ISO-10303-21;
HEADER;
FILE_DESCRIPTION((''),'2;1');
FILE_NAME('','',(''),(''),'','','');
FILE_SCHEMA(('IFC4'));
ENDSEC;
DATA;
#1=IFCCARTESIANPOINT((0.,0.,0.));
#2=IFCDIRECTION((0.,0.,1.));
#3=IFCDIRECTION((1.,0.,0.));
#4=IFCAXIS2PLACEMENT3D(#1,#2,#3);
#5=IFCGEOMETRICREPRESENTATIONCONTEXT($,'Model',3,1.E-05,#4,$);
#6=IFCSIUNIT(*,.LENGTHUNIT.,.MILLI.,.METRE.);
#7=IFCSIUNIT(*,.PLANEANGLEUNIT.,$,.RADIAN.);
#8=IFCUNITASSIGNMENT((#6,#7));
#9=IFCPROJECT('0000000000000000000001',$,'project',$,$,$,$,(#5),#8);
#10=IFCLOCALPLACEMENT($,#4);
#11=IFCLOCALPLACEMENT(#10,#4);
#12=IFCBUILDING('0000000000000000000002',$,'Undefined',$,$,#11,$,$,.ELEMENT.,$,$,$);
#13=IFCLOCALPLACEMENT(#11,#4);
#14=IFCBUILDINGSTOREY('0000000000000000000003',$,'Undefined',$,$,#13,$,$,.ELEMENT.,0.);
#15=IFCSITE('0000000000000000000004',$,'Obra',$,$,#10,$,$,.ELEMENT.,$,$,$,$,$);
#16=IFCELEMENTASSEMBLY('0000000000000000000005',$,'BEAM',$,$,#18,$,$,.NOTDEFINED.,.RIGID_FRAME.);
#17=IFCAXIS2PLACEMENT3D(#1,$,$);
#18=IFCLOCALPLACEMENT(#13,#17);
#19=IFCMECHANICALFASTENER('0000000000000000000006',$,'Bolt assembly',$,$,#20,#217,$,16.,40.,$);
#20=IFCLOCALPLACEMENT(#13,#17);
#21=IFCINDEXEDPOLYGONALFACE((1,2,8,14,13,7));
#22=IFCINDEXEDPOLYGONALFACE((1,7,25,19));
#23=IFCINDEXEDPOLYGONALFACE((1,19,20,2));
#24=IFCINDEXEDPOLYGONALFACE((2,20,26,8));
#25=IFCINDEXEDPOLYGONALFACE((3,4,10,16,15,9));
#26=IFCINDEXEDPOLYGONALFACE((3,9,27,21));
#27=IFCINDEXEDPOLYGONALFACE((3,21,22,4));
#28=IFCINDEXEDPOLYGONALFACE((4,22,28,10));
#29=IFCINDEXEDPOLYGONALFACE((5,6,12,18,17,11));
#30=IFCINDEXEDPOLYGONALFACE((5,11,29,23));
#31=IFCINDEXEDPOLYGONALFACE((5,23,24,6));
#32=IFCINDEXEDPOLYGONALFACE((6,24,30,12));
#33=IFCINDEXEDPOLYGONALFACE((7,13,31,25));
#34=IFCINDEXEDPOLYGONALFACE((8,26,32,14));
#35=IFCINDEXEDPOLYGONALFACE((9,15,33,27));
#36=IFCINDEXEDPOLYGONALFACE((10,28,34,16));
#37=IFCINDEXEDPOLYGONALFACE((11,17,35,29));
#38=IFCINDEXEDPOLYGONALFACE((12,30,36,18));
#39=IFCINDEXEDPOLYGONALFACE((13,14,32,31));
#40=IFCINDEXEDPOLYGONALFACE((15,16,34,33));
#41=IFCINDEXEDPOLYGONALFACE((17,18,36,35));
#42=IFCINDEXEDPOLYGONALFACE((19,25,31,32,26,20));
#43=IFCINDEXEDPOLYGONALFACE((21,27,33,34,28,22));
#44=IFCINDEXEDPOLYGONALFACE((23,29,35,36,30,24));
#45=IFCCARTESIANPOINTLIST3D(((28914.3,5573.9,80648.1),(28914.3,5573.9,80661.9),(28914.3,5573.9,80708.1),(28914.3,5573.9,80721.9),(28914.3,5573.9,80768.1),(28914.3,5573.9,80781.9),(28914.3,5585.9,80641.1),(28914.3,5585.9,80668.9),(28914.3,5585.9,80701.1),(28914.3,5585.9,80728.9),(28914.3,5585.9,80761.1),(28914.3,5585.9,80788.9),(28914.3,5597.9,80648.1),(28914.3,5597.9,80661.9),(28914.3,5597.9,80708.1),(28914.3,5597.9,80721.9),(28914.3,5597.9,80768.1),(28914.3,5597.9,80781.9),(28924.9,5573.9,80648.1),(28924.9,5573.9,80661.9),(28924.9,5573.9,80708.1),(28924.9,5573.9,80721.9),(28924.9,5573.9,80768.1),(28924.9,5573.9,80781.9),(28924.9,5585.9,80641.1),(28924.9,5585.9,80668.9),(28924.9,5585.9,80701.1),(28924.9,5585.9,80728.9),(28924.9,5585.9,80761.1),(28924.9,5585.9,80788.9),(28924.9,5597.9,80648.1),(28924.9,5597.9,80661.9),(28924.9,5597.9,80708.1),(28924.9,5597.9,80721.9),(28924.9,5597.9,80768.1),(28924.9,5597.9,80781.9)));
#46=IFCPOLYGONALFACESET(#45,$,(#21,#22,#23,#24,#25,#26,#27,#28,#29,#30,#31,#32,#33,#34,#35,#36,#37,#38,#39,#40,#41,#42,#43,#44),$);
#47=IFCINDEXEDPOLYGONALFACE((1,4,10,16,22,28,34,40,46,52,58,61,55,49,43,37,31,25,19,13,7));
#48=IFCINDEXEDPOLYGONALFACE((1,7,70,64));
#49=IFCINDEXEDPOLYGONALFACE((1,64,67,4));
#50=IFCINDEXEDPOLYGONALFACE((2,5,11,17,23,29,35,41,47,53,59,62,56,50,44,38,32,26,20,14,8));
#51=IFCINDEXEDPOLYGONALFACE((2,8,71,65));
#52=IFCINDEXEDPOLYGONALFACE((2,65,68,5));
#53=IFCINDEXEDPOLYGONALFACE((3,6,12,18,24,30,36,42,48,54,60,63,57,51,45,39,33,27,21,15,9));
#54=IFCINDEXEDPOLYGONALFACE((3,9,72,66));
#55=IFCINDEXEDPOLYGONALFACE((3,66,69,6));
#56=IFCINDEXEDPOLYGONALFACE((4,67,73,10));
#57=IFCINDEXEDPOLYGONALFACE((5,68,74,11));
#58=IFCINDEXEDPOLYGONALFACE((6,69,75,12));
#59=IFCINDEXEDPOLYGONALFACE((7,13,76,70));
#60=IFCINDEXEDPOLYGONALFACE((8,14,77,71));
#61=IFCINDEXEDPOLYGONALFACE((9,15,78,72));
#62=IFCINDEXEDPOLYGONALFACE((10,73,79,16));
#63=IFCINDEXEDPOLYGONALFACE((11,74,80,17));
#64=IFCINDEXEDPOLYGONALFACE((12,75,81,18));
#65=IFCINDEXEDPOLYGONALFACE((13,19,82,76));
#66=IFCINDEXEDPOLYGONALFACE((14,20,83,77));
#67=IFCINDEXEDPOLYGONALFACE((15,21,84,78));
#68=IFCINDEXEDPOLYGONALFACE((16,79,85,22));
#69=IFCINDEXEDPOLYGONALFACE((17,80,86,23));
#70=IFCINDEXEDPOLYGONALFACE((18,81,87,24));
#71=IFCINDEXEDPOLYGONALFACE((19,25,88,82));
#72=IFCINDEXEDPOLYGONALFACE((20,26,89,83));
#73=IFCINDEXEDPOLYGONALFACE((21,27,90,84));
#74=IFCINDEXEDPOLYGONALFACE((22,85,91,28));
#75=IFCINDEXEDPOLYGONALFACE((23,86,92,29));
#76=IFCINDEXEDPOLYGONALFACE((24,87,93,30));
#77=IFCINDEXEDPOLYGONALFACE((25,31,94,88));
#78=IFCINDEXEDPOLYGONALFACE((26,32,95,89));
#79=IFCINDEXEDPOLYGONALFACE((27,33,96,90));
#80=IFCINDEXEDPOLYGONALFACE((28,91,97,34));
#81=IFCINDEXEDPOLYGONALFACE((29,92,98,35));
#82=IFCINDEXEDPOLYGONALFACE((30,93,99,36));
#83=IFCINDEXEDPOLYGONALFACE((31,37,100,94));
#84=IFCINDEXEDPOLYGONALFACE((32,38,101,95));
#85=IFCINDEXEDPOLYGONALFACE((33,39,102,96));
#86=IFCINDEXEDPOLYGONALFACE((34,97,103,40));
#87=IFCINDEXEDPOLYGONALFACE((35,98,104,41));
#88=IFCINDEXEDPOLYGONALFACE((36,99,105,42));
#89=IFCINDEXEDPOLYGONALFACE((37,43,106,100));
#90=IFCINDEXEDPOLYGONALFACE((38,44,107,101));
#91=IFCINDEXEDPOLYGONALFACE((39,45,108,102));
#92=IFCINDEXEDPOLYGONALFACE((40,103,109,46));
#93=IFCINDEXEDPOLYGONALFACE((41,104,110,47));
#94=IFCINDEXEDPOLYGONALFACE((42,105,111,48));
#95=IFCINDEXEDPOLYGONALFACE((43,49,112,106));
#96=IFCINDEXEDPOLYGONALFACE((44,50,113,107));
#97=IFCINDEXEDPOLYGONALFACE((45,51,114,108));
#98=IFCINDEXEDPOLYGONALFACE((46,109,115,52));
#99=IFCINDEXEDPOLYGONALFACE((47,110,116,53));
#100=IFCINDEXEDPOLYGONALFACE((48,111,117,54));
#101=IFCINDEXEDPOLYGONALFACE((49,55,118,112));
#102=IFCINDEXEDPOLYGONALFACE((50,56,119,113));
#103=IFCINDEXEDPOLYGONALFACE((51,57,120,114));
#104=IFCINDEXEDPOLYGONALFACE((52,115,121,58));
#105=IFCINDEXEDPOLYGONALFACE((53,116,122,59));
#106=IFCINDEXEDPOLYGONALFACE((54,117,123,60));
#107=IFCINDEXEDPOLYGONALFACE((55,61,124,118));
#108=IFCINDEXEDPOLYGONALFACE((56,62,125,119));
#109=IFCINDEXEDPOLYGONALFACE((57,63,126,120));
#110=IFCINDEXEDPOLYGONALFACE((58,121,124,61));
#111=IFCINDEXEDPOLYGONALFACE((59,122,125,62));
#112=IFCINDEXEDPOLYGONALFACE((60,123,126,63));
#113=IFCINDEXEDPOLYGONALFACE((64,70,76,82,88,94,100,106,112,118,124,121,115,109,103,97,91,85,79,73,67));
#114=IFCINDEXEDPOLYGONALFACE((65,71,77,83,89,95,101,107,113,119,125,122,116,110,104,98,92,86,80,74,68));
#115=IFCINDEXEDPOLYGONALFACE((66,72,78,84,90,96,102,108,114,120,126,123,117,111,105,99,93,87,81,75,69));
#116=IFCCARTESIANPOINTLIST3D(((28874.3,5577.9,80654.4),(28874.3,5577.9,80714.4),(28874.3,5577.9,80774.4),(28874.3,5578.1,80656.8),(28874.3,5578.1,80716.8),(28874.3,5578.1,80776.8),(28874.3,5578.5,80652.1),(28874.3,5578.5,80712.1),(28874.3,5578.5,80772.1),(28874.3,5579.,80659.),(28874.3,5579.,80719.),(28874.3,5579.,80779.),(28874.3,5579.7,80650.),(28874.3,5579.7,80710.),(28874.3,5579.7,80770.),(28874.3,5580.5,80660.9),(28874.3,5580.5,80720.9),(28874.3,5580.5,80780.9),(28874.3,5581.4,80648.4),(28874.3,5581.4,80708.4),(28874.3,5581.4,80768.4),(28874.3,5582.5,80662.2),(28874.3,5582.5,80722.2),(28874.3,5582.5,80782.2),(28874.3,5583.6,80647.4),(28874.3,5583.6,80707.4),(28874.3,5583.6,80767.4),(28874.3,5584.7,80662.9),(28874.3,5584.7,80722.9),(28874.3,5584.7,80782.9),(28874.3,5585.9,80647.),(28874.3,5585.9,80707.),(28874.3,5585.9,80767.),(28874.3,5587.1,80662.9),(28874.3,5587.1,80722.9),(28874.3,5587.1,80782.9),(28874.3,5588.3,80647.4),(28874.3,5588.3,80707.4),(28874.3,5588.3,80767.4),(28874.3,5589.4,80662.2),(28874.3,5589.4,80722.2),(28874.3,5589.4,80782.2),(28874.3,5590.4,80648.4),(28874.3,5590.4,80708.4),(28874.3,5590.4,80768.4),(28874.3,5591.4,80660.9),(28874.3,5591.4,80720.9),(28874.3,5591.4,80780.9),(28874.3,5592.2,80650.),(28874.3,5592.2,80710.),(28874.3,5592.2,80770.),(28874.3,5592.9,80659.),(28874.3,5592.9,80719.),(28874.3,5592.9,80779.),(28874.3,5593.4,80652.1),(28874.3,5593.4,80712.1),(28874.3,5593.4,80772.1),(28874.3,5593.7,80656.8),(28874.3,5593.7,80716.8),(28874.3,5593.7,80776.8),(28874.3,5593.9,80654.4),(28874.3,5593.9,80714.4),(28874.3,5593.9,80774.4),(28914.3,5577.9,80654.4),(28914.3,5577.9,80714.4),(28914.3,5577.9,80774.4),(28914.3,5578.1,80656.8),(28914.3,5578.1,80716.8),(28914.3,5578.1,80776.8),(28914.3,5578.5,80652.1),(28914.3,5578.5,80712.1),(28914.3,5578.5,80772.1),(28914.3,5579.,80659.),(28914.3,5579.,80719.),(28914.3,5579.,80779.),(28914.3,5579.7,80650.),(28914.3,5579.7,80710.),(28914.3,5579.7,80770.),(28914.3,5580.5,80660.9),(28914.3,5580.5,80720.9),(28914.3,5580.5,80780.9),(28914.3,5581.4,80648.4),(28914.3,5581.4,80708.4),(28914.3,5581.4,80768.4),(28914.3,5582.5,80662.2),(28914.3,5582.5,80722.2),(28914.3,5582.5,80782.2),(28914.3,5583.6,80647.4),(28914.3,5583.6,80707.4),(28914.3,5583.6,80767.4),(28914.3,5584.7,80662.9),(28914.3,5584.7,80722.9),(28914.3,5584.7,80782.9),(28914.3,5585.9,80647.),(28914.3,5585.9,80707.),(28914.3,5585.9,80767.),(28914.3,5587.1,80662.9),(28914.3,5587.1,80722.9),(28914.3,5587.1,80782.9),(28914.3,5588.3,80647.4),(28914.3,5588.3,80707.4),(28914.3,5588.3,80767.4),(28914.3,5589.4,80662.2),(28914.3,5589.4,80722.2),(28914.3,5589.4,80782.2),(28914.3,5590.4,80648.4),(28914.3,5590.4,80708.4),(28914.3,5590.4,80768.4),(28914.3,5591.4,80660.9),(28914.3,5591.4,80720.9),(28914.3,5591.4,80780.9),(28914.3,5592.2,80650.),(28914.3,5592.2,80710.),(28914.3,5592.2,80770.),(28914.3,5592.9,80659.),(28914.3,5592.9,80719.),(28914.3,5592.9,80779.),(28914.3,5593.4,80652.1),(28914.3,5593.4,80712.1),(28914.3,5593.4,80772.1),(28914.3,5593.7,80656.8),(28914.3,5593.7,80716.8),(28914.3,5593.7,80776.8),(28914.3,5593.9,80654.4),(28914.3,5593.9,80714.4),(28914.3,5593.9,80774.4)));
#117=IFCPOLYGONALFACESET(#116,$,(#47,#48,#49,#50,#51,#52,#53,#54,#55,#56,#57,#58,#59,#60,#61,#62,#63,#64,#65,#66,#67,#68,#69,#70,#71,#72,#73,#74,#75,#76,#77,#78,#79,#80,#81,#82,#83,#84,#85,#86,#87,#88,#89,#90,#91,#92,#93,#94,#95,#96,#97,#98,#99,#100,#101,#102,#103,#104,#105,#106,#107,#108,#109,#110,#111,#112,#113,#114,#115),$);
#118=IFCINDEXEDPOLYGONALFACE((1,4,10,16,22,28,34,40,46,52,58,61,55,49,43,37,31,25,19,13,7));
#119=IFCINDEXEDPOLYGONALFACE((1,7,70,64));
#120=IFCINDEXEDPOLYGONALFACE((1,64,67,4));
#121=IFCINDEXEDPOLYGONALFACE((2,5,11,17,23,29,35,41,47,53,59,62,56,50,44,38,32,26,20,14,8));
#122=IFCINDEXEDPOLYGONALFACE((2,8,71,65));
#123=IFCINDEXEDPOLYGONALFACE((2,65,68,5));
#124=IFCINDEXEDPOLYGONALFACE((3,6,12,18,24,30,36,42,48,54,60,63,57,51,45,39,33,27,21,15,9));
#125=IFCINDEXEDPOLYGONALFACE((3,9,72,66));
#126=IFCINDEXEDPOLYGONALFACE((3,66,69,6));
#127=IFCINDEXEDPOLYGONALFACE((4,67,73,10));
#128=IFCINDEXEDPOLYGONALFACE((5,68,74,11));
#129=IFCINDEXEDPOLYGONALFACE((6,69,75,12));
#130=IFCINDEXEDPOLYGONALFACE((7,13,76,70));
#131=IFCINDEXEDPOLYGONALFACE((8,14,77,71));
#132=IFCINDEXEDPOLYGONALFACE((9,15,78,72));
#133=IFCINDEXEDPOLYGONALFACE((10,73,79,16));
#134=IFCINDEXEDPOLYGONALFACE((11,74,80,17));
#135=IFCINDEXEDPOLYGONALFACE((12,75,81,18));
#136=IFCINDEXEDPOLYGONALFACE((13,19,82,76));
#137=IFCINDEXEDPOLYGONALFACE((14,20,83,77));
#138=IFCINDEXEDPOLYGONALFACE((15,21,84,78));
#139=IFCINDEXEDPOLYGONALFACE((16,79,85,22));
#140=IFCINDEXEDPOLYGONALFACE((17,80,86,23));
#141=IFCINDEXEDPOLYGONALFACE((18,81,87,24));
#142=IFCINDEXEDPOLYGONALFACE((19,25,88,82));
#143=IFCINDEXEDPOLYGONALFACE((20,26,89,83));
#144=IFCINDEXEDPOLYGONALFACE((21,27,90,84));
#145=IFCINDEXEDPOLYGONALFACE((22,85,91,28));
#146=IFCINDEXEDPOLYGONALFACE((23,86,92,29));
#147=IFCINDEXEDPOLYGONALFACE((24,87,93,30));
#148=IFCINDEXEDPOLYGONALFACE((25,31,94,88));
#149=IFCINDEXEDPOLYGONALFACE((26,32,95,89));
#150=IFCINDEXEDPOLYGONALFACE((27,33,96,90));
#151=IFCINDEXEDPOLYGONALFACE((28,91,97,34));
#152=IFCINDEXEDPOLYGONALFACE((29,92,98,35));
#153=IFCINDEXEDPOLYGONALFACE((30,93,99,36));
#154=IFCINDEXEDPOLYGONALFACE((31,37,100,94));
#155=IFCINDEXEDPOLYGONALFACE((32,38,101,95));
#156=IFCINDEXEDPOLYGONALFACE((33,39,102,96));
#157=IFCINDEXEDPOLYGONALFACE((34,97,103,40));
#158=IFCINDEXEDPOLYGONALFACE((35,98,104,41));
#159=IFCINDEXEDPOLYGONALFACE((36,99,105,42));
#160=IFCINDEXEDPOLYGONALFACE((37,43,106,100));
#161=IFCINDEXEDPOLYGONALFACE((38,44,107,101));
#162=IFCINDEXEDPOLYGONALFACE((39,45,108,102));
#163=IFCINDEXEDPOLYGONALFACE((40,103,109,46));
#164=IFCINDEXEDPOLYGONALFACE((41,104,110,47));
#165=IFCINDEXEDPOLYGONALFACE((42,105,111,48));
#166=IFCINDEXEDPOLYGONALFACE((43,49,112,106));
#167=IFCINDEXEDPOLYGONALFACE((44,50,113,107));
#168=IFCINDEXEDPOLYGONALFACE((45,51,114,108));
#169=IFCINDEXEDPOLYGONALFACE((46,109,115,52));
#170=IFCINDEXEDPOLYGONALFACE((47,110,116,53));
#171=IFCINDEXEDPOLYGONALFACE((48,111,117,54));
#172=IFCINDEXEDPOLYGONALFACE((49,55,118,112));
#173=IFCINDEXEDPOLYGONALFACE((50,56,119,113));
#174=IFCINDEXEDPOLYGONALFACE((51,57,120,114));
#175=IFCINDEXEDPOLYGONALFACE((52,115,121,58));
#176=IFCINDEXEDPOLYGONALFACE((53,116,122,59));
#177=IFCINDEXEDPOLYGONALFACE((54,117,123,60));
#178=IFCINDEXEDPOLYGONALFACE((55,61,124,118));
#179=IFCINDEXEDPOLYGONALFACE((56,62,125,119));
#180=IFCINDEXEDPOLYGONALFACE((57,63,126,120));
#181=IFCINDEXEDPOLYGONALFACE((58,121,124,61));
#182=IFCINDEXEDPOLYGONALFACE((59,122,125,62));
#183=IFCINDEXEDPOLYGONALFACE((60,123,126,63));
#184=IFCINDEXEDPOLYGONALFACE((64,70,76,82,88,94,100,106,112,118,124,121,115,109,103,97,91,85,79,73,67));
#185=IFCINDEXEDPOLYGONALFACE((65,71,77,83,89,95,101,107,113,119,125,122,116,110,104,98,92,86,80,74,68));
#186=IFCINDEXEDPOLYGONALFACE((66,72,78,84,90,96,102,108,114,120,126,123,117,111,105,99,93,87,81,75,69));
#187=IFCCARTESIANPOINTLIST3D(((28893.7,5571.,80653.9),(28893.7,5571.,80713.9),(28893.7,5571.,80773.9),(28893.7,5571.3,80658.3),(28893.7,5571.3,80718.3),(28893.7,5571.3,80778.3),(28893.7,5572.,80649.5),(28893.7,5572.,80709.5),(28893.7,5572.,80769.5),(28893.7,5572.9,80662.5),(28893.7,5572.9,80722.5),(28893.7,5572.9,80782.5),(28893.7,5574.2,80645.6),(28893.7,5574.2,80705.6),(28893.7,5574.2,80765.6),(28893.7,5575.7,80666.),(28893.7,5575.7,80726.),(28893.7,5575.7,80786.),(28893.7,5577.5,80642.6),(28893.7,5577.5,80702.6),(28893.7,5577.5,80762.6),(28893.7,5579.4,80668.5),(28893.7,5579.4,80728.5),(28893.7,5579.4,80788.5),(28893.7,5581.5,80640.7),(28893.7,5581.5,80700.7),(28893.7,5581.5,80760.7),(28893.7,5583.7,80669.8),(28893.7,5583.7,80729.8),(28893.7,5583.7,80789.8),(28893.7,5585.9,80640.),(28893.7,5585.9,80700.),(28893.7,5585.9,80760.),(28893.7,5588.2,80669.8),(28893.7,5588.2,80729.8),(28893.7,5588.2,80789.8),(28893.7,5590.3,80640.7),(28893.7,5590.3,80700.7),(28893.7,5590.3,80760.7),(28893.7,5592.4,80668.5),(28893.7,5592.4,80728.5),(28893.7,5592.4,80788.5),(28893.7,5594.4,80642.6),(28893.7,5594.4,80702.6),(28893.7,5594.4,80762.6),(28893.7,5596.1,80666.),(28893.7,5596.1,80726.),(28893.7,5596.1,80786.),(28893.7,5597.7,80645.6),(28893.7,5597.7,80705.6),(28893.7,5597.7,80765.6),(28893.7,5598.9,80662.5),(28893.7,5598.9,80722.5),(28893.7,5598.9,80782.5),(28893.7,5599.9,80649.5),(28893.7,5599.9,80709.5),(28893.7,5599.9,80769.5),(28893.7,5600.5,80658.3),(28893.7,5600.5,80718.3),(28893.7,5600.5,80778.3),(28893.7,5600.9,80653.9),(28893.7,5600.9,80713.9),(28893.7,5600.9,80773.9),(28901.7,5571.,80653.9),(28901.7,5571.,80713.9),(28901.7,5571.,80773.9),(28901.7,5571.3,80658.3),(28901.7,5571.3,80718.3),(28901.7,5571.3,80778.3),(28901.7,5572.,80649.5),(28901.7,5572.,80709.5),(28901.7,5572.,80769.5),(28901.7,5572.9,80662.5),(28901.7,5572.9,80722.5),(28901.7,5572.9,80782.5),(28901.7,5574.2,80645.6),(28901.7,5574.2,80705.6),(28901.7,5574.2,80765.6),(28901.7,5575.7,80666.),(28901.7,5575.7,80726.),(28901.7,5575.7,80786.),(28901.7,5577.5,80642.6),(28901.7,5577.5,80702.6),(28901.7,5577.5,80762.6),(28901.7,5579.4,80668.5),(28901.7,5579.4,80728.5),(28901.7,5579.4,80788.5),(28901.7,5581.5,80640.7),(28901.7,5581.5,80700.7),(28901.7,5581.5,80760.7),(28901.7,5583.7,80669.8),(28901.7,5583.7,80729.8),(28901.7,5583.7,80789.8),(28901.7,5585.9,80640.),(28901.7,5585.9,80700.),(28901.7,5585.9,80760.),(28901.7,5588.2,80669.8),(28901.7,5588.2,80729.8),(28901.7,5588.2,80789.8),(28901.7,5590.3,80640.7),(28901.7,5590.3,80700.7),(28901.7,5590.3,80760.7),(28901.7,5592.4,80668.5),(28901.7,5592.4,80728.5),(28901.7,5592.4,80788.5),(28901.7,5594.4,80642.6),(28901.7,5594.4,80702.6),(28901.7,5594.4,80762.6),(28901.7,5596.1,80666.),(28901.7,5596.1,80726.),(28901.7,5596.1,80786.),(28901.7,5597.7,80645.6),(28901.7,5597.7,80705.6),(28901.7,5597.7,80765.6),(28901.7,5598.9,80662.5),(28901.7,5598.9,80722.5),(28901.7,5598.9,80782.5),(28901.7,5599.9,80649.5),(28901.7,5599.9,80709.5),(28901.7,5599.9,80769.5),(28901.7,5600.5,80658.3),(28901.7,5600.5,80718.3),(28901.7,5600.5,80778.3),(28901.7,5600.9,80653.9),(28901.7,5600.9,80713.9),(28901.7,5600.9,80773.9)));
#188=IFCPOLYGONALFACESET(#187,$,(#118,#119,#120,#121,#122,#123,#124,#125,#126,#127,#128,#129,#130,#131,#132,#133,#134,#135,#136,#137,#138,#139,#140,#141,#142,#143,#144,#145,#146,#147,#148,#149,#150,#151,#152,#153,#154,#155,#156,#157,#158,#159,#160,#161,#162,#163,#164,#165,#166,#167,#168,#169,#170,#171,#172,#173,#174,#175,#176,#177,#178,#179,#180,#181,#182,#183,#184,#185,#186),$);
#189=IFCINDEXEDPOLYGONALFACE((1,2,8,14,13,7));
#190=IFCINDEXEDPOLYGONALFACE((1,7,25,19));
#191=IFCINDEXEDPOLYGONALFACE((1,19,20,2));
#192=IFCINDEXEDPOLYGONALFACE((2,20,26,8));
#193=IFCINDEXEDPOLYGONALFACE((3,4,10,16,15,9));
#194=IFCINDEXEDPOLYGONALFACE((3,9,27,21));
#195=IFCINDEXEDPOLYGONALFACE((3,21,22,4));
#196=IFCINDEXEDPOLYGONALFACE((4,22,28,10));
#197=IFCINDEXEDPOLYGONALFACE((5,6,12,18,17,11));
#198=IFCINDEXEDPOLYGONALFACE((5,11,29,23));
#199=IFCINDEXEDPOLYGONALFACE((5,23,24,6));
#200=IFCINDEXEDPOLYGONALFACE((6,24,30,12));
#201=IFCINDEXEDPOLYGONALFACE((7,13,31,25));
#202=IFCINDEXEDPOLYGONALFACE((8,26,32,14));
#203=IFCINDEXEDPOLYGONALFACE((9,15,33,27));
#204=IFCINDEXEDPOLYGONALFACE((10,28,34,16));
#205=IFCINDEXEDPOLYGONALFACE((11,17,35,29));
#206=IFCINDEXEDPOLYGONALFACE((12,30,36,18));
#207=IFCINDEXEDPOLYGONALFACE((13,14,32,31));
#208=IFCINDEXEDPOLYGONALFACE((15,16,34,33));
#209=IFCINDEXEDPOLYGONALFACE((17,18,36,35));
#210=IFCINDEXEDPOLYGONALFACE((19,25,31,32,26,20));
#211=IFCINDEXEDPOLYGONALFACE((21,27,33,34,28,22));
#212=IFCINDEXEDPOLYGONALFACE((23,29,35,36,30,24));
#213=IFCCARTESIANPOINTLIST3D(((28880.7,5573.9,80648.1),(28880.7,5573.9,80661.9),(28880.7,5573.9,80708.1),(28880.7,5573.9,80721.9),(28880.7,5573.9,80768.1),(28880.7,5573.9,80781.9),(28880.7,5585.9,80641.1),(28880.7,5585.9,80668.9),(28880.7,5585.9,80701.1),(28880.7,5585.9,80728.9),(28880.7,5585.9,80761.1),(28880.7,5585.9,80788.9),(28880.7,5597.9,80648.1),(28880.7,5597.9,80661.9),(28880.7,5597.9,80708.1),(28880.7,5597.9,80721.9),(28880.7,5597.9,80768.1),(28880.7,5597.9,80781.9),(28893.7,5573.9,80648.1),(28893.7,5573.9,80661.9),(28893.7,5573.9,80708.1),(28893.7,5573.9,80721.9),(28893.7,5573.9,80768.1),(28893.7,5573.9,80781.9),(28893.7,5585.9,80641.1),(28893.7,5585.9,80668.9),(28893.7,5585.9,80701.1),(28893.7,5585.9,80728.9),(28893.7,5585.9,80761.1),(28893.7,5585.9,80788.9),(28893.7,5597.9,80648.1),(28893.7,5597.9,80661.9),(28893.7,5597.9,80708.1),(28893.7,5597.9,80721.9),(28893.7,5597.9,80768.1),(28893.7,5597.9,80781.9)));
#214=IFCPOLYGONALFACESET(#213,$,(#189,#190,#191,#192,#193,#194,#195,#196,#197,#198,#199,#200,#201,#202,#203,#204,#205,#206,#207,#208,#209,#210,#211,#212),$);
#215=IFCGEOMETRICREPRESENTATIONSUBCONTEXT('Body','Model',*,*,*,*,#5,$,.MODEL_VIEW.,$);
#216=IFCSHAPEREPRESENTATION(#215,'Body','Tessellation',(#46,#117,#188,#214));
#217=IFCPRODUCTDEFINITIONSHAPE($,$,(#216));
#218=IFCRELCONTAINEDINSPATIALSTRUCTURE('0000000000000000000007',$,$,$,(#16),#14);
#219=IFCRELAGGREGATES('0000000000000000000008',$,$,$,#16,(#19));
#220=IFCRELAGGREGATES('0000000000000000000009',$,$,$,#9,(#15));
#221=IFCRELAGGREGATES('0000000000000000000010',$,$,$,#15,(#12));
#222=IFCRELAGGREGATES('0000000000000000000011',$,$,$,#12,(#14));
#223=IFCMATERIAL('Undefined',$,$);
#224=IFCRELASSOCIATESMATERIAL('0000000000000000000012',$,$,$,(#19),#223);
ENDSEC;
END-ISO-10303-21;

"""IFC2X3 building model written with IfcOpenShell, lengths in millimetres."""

from ifc_helpers import new_model, si_unit, frame, origin_with_axes, origin_2d_with_axis, place, context, subcontext, project, spatial, polyline, circle, outline, extrude, source, transform, mapped, material, element, aggregate, save


model = new_model("IFC2X3")

# Units and contexts
model_context = context("Model", 3, precision=1e-05, world=origin_with_axes())
body_context = subcontext(model_context, "Body", "Model", "MODEL_VIEW")
ifc_project = project(units=[si_unit("LENGTHUNIT", "METRE", prefix="MILLI"), si_unit("PLANEANGLEUNIT", "RADIAN")], contexts=[model_context])

# Site, building, storey
site_placement = place(None, origin_with_axes())
site = spatial("IfcSite", under=ifc_project, at=site_placement, Name="Obra", CompositionType="ELEMENT")
building_placement = place(site_placement, origin_with_axes())
building = spatial("IfcBuilding", under=site, at=building_placement, Name="Undefined", CompositionType="ELEMENT")
storey_placement = place(building_placement, origin_with_axes())
storey = spatial("IfcBuildingStorey", under=building, at=storey_placement, Name="Undefined", CompositionType="ELEMENT", Elevation=0.0)

# Shared definitions
ifc_material_1 = material(Name="Undefined")

# Element assembly, mechanical fastener
assembly_1_placement = place(storey_placement, origin_with_axes())
assembly_1 = element("IfcElementAssembly", 1, at=assembly_1_placement, inside=storey, Name="BEAM", AssemblyPlace="NOTDEFINED", PredefinedType="RIGID_FRAME")
shared_shape_1 = source(origin_with_axes(), body_context, "Body", "SweptSolid", [
    extrude(outline(polyline([(13.9, 0.0), (6.9, 12.0), (-6.9, 12.0), (-13.9, 0.0), (-6.9, -12.0), (6.9, -12.0), (13.9, 0.0)])), frame((0.0, -19.9, 0.0), z_axis=(0.0, 1.0, 0.0), x_axis=(1.0, 0.0, 0.0)), (0.0, 0.0, 1.0), 10.6),
    extrude(circle(Radius=8.0, at=origin_2d_with_axis()), frame((0.0, -9.3, 0.0), z_axis=(0.0, 1.0, 0.0), x_axis=(1.0, 0.0, 0.0)), (0.0, 0.0, 1.0), 40.0),
    extrude(circle(Radius=15.0, at=origin_2d_with_axis()), frame((0.0, 3.3, 0.0), z_axis=(0.0, 1.0, 0.0), x_axis=(1.0, 0.0, 0.0)), (0.0, 0.0, 1.0), 8.0),
    extrude(outline(polyline([(13.9, 0.0), (6.9, 12.0), (-6.9, 12.0), (-13.9, 0.0), (-6.9, -12.0), (6.9, -12.0), (13.9, 0.0)])), frame((0.0, 11.3, 0.0), z_axis=(0.0, 1.0, 0.0), x_axis=(1.0, 0.0, 0.0)), (0.0, 0.0, 1.0), 13.0),
])
mechanical_fastener_1_placement = place(assembly_1_placement, frame((28905.0, 5535.9, 80850.0), z_axis=(-0.000001, 1.0, 0.0), x_axis=(0.0, 0.0, -1.0)))
mechanical_fastener_1 = element("IfcMechanicalFastener", 2, at=mechanical_fastener_1_placement, material=ifc_material_1, Name="Bolt assembly", NominalDiameter=16.0, NominalLength=40.0, context=body_context, shape_type="MappedRepresentation", body=[
    mapped(shared_shape_1, transform((75.0, 0.0, 50.0))),
    mapped(shared_shape_1, transform((135.0, 0.0, 50.0))),
    mapped(shared_shape_1, transform((195.0, 0.0, 50.0))),
])
aggregate(assembly_1, [mechanical_fastener_1])

save(model, "model.ifc")
